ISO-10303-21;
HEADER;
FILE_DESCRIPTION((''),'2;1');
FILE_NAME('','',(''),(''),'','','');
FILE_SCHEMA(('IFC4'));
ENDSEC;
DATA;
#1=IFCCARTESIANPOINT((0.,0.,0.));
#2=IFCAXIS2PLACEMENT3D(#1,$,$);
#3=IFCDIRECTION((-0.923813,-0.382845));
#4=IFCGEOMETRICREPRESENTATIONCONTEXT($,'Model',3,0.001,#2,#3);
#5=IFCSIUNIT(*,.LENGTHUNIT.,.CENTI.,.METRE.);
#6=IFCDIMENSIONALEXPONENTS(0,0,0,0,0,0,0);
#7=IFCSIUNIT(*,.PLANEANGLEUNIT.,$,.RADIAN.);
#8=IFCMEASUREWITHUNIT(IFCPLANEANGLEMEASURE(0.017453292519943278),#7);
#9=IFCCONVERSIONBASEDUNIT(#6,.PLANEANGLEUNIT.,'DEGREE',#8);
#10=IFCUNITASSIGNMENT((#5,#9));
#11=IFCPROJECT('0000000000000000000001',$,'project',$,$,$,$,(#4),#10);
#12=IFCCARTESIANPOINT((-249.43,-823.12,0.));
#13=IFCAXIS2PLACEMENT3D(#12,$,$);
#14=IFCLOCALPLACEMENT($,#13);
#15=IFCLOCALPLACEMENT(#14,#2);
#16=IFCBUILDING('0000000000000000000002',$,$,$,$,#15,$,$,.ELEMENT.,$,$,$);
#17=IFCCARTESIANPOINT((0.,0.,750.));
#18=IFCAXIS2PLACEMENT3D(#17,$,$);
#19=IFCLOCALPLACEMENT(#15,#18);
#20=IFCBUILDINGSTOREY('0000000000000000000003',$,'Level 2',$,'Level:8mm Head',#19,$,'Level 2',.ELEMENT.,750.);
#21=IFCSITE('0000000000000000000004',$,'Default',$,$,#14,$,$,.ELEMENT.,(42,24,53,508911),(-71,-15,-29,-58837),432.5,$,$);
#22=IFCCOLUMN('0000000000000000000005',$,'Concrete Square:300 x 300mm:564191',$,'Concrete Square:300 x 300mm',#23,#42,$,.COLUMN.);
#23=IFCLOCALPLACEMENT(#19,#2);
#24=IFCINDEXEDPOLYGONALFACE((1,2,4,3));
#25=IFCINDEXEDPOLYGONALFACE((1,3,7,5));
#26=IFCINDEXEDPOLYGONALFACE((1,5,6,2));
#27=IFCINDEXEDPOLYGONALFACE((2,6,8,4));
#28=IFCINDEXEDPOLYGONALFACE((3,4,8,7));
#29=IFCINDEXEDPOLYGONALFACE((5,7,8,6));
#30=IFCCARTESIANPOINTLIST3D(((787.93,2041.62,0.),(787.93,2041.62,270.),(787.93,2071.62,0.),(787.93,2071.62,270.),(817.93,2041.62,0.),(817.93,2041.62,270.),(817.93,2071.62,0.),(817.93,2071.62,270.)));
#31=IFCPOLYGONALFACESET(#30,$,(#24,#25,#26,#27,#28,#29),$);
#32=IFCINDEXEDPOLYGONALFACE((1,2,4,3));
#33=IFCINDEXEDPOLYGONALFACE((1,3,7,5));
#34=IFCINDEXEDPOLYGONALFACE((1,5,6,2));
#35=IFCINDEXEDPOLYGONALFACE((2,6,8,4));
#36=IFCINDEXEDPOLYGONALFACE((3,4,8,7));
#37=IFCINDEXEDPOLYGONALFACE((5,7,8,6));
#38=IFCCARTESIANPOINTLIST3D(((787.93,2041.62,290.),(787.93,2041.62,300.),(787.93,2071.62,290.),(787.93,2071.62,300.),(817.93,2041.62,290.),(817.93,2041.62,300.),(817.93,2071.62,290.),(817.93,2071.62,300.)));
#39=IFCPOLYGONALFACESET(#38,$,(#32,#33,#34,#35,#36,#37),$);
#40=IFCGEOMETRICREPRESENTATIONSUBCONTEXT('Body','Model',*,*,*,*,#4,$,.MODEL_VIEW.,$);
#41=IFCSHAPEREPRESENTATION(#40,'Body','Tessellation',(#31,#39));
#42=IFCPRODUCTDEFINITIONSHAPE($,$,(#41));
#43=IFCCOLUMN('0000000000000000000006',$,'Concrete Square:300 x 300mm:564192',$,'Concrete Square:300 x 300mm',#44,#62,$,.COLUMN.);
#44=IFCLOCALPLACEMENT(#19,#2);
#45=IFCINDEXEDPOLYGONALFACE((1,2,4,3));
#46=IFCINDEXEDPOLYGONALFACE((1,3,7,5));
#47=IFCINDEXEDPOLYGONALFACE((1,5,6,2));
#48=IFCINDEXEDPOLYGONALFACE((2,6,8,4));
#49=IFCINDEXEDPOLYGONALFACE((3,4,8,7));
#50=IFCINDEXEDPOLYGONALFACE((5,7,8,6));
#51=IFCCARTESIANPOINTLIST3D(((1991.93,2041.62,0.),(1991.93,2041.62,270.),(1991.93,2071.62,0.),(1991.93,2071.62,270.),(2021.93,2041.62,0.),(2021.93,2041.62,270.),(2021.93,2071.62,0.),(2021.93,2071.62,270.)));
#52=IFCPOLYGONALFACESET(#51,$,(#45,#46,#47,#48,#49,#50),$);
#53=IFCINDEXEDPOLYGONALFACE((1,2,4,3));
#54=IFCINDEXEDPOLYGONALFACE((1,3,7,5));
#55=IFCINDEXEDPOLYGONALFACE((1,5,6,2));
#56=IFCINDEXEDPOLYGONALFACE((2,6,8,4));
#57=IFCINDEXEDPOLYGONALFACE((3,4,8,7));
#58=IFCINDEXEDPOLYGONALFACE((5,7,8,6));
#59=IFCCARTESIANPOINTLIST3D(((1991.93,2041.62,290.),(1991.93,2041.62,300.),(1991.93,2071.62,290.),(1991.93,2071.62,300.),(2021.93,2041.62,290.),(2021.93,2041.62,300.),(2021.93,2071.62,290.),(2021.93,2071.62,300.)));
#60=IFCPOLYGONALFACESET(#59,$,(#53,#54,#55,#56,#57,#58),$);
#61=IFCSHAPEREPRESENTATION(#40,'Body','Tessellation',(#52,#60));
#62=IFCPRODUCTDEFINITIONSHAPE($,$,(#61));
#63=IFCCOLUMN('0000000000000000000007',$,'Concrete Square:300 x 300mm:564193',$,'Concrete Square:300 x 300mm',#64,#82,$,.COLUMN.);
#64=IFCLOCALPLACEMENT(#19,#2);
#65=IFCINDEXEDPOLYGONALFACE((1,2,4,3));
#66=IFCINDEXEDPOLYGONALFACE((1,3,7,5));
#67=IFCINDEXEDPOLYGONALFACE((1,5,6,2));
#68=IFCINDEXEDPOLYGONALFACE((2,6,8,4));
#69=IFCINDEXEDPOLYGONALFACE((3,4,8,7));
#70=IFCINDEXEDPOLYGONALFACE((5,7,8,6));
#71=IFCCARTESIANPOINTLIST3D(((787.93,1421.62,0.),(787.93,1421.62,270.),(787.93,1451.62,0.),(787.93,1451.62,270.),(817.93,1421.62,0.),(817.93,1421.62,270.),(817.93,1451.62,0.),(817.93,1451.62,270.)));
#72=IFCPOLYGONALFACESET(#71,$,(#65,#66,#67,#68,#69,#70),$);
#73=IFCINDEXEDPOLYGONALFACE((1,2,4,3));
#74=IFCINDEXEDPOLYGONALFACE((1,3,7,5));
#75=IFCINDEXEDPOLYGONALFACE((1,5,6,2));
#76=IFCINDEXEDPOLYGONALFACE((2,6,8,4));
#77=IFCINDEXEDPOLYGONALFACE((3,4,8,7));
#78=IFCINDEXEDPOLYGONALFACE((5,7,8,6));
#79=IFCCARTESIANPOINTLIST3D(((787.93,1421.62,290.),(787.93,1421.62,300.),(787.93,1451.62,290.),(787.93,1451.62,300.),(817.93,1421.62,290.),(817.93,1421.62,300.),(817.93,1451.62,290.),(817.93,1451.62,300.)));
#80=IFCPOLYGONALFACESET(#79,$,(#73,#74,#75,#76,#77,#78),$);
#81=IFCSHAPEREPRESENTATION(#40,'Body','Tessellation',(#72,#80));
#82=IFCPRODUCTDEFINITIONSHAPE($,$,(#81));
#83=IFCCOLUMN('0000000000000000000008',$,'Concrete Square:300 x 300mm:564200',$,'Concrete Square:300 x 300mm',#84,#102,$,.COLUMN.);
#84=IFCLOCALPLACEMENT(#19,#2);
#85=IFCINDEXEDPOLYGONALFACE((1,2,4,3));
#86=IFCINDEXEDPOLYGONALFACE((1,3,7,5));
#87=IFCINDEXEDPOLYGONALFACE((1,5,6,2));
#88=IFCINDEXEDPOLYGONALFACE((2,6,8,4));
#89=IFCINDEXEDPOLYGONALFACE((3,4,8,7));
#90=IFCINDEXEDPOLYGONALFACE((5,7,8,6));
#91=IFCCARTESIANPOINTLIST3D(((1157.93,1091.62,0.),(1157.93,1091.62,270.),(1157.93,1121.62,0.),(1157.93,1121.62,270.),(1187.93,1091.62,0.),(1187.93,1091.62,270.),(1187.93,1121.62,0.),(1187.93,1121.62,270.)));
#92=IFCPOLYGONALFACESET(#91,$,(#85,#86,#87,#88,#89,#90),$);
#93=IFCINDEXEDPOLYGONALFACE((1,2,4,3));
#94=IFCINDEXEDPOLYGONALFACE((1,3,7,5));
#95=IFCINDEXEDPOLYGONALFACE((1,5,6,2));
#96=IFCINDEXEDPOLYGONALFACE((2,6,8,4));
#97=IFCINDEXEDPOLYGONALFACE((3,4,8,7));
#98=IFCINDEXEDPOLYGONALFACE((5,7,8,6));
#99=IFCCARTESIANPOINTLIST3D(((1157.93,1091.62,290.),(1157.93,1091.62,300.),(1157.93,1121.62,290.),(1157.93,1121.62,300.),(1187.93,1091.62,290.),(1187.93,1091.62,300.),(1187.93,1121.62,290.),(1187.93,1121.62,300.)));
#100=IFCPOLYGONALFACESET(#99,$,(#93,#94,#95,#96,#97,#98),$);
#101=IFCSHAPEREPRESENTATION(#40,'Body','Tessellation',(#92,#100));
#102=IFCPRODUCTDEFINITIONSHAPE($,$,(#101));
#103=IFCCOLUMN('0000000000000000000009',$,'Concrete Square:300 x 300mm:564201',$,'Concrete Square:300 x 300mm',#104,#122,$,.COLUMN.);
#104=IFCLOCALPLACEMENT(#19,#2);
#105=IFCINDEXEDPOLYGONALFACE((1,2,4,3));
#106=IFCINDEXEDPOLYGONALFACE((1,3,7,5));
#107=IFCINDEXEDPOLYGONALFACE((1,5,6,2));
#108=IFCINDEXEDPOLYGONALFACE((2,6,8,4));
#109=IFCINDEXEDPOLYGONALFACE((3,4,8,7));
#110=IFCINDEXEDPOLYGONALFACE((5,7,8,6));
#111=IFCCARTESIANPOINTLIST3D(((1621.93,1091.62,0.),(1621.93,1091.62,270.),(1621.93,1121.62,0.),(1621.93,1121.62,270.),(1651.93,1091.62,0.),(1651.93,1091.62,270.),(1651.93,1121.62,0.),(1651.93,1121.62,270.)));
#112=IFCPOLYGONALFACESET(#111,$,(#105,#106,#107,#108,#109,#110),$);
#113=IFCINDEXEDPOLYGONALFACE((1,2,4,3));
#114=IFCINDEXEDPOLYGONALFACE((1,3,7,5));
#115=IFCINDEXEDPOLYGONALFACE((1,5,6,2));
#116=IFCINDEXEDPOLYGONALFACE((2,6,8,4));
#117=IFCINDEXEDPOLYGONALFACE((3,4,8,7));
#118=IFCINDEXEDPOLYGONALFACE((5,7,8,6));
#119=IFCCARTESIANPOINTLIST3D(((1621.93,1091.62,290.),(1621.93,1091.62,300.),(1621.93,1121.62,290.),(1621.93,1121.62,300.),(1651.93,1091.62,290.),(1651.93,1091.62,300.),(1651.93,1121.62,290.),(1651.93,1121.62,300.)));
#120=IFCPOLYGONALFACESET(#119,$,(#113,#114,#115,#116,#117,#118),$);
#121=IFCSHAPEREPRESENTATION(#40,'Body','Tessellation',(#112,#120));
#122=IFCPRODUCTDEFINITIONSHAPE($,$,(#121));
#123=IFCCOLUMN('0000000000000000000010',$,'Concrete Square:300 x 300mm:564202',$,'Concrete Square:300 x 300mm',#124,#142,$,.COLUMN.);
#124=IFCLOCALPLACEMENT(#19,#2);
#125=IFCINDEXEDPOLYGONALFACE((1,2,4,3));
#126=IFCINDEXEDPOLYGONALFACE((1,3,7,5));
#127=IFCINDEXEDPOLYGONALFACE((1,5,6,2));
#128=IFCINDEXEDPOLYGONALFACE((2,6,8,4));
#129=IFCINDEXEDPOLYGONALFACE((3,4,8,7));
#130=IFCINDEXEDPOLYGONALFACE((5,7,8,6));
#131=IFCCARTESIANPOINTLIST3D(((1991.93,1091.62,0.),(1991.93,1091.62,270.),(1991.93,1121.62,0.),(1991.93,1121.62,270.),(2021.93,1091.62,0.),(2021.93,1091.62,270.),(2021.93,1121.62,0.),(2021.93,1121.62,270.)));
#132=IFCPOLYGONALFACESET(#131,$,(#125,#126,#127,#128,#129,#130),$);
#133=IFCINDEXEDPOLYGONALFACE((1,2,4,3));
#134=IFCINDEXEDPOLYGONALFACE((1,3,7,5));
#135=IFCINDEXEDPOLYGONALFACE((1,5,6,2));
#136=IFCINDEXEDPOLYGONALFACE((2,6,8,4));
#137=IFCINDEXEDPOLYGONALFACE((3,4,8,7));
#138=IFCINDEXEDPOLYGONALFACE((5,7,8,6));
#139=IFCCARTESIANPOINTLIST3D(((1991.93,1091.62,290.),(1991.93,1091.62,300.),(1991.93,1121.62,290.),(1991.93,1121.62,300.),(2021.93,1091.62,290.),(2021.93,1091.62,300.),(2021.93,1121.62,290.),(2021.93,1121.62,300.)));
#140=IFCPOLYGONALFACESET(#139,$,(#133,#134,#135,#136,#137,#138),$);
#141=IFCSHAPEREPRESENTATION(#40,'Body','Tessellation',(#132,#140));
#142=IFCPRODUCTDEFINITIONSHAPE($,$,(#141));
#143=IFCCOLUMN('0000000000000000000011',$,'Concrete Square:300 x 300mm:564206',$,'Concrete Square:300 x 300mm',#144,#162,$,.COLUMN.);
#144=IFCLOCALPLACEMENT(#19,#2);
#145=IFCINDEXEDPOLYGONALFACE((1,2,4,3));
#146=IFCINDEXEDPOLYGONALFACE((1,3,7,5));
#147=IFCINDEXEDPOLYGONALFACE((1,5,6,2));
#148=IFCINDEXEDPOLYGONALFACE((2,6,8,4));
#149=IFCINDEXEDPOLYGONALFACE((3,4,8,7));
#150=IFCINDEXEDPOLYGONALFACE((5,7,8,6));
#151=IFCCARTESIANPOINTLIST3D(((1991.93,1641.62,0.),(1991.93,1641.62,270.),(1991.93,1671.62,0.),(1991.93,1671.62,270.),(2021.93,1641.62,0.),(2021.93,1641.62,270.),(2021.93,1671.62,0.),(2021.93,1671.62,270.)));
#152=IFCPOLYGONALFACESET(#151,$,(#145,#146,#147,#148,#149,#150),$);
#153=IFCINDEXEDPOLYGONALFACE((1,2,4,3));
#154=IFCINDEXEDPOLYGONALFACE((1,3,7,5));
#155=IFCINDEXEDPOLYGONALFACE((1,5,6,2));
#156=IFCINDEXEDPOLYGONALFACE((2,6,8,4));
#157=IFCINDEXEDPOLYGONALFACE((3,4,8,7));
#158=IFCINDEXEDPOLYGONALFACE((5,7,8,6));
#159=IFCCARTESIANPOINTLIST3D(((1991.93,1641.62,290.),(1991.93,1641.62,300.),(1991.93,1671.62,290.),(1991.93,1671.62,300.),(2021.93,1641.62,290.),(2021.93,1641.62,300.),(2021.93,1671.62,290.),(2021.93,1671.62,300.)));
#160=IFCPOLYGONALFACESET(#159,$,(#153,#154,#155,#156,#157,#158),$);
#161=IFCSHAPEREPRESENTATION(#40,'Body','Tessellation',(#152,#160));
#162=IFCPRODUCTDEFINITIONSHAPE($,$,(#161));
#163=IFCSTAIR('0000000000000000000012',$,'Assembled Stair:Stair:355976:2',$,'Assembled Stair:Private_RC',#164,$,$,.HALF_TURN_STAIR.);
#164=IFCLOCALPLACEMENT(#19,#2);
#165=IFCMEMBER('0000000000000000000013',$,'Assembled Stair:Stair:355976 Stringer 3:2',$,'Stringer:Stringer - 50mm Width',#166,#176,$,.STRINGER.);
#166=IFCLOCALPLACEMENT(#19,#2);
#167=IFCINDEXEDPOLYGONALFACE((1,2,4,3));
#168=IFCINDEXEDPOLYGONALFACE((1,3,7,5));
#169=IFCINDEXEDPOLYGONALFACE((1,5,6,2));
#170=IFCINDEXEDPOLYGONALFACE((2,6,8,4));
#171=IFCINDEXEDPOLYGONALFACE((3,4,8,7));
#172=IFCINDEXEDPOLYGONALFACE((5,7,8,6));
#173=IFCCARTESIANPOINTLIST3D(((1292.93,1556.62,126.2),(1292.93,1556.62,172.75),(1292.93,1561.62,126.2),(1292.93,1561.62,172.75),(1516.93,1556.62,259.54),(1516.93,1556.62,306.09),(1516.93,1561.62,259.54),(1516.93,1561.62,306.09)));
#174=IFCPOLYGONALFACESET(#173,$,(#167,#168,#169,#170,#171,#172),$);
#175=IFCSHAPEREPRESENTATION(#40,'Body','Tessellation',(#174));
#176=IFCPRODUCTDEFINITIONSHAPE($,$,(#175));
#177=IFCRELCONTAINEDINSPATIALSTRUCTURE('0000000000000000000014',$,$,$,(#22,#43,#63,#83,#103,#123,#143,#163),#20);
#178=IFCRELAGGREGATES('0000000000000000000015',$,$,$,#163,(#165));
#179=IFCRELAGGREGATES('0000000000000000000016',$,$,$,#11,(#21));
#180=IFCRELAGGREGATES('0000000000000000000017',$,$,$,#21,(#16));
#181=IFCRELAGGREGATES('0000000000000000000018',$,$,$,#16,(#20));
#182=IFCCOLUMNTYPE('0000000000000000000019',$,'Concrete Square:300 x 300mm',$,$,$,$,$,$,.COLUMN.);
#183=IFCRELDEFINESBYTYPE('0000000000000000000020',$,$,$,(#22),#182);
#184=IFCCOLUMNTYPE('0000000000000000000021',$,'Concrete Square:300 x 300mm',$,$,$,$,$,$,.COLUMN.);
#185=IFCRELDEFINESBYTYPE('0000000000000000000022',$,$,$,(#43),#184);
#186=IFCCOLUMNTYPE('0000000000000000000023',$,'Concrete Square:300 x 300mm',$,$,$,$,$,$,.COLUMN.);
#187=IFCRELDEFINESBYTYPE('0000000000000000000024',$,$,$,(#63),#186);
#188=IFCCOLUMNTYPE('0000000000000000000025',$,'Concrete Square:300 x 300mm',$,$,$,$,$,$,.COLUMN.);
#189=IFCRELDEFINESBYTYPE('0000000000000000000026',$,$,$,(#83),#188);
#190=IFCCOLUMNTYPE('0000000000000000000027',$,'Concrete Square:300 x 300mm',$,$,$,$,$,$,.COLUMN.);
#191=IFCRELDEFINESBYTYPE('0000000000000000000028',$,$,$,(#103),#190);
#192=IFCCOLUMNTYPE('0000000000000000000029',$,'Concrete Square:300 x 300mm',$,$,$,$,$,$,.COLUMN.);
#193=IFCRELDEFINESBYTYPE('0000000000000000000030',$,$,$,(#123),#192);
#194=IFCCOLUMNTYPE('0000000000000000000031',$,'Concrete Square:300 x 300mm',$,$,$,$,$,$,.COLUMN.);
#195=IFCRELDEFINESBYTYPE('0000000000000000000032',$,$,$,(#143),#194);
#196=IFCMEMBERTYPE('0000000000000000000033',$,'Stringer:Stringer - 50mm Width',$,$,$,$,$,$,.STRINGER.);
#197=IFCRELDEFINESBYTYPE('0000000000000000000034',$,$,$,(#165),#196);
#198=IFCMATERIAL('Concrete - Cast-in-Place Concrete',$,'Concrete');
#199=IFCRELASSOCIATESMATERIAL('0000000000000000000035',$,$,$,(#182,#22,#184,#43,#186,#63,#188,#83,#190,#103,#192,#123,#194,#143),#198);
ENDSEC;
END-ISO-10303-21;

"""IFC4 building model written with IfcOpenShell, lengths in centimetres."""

from ifc_helpers import new_model, entity, si_unit, converted_unit, direction, frame, origin, place, context, subcontext, project, spatial, indexed_curve, outline, extrude, source, transform, mapped, material, type_object, type_shapes, element, aggregate, save


model = new_model("IFC4")

# Units and contexts
model_context = context("Model", 3, precision=0.001, world=origin(), true_north=direction((-0.923813, -0.382845)))
body_context = subcontext(model_context, "Body", "Model", "MODEL_VIEW")
ifc_project = project(units=[si_unit("LENGTHUNIT", "METRE", prefix="CENTI"), converted_unit("PLANEANGLEUNIT", "DEGREE", entity("IfcPlaneAngleMeasure", 0.017453292519943278), si_unit("PLANEANGLEUNIT", "RADIAN"), dimensions=[0, 0, 0, 0, 0, 0, 0])], contexts=[model_context])

# Site, building, storey
site_placement = place(None, frame((-249.43, -823.12, 0.0)))
site = spatial("IfcSite", under=ifc_project, at=site_placement, Name="Default", CompositionType="ELEMENT", RefLatitude=(42, 24, 53, 508911), RefLongitude=(-71, -15, -29, -58837), RefElevation=432.5)
building_placement = place(site_placement, origin())
building = spatial("IfcBuilding", under=site, at=building_placement, CompositionType="ELEMENT")
storey_placement = place(building_placement, frame((0.0, 0.0, 750.0)))
storey = spatial("IfcBuildingStorey", under=building, at=storey_placement, Name="Level 2", ObjectType="Level:8mm Head", LongName="Level 2", CompositionType="ELEMENT", Elevation=750.0)

# Columns
ifc_material_1 = material(Name="Concrete - Cast-in-Place Concrete", Category="Concrete")
column_type_1 = type_object("IfcColumnType", Name="Concrete Square:300 x 300mm", PredefinedType="COLUMN", material=ifc_material_1)
shared_shape_1 = source(origin(), body_context, "Body", "SweptSolid", [
    extrude(outline(indexed_curve([(-15.0, -15.0), (15.0, -15.0), (15.0, 15.0), (-15.0, 15.0), (-15.0, -15.0)], self_intersect=False)), frame((802.93, 2056.62, 750.0), z_axis=(0.0, 0.0, 1.0), x_axis=(-1.0, 0.0, 0.0)), (0.0, 0.0, 1.0), 270.0),
    extrude(outline(indexed_curve([(-15.0, -15.0), (15.0, -15.0), (15.0, 15.0), (-15.0, 15.0), (-15.0, -15.0)], self_intersect=False)), frame((802.93, 2056.62, 1040.0), z_axis=(0.0, 0.0, 1.0), x_axis=(-1.0, 0.0, 0.0)), (0.0, 0.0, 1.0), 10.0),
])
type_shapes(column_type_1, [shared_shape_1])
column_1_placement = place(storey_placement, frame((0.0, 0.0, -750.0)))
element("IfcColumn", 1, at=column_1_placement, inside=storey, type_object=column_type_1, material=ifc_material_1, Name="Concrete Square:300 x 300mm:564191", ObjectType="Concrete Square:300 x 300mm", PredefinedType="COLUMN", context=body_context, shape_type="MappedRepresentation", body=[
    mapped(shared_shape_1, transform((0.0, 0.0, 0.0), scale=1.0)),
])
column_type_2 = type_object("IfcColumnType", Name="Concrete Square:300 x 300mm", PredefinedType="COLUMN", material=ifc_material_1)
shared_shape_2 = source(origin(), body_context, "Body", "SweptSolid", [
    extrude(outline(indexed_curve([(-15.0, -15.0), (15.0, -15.0), (15.0, 15.0), (-15.0, 15.0), (-15.0, -15.0)], self_intersect=False)), frame((2006.93, 2056.62, 750.0), z_axis=(0.0, 0.0, 1.0), x_axis=(-1.0, 0.0, 0.0)), (0.0, 0.0, 1.0), 270.0),
    extrude(outline(indexed_curve([(-15.0, -15.0), (15.0, -15.0), (15.0, 15.0), (-15.0, 15.0), (-15.0, -15.0)], self_intersect=False)), frame((2006.93, 2056.62, 1040.0), z_axis=(0.0, 0.0, 1.0), x_axis=(-1.0, 0.0, 0.0)), (0.0, 0.0, 1.0), 10.0),
])
type_shapes(column_type_2, [shared_shape_2])
column_2_placement = place(storey_placement, frame((0.0, 0.0, -750.0)))
element("IfcColumn", 2, at=column_2_placement, inside=storey, type_object=column_type_2, material=ifc_material_1, Name="Concrete Square:300 x 300mm:564192", ObjectType="Concrete Square:300 x 300mm", PredefinedType="COLUMN", context=body_context, shape_type="MappedRepresentation", body=[
    mapped(shared_shape_2, transform((0.0, 0.0, 0.0), scale=1.0)),
])
column_type_3 = type_object("IfcColumnType", Name="Concrete Square:300 x 300mm", PredefinedType="COLUMN", material=ifc_material_1)
shared_shape_3 = source(origin(), body_context, "Body", "SweptSolid", [
    extrude(outline(indexed_curve([(-15.0, -15.0), (15.0, -15.0), (15.0, 15.0), (-15.0, 15.0), (-15.0, -15.0)], self_intersect=False)), frame((802.93, 1436.62, 750.0), z_axis=(0.0, 0.0, 1.0), x_axis=(-1.0, 0.0, 0.0)), (0.0, 0.0, 1.0), 270.0),
    extrude(outline(indexed_curve([(-15.0, -15.0), (15.0, -15.0), (15.0, 15.0), (-15.0, 15.0), (-15.0, -15.0)], self_intersect=False)), frame((802.93, 1436.62, 1040.0), z_axis=(0.0, 0.0, 1.0), x_axis=(-1.0, 0.0, 0.0)), (0.0, 0.0, 1.0), 10.0),
])
type_shapes(column_type_3, [shared_shape_3])
column_3_placement = place(storey_placement, frame((0.0, 0.0, -750.0)))
element("IfcColumn", 3, at=column_3_placement, inside=storey, type_object=column_type_3, material=ifc_material_1, Name="Concrete Square:300 x 300mm:564193", ObjectType="Concrete Square:300 x 300mm", PredefinedType="COLUMN", context=body_context, shape_type="MappedRepresentation", body=[
    mapped(shared_shape_3, transform((0.0, 0.0, 0.0), scale=1.0)),
])
column_type_4 = type_object("IfcColumnType", Name="Concrete Square:300 x 300mm", PredefinedType="COLUMN", material=ifc_material_1)
shared_shape_4 = source(origin(), body_context, "Body", "SweptSolid", [
    extrude(outline(indexed_curve([(-15.0, -15.0), (15.0, -15.0), (15.0, 15.0), (-15.0, 15.0), (-15.0, -15.0)], self_intersect=False)), frame((1172.93, 1106.62, 750.0), z_axis=(0.0, 0.0, 1.0), x_axis=(-1.0, 0.0, 0.0)), (0.0, 0.0, 1.0), 270.0),
    extrude(outline(indexed_curve([(-15.0, -15.0), (15.0, -15.0), (15.0, 15.0), (-15.0, 15.0), (-15.0, -15.0)], self_intersect=False)), frame((1172.93, 1106.62, 1040.0), z_axis=(0.0, 0.0, 1.0), x_axis=(-1.0, 0.0, 0.0)), (0.0, 0.0, 1.0), 10.0),
])
type_shapes(column_type_4, [shared_shape_4])
column_4_placement = place(storey_placement, frame((0.0, 0.0, -750.0)))
element("IfcColumn", 4, at=column_4_placement, inside=storey, type_object=column_type_4, material=ifc_material_1, Name="Concrete Square:300 x 300mm:564200", ObjectType="Concrete Square:300 x 300mm", PredefinedType="COLUMN", context=body_context, shape_type="MappedRepresentation", body=[
    mapped(shared_shape_4, transform((0.0, 0.0, 0.0), scale=1.0)),
])
column_type_5 = type_object("IfcColumnType", Name="Concrete Square:300 x 300mm", PredefinedType="COLUMN", material=ifc_material_1)
shared_shape_5 = source(origin(), body_context, "Body", "SweptSolid", [
    extrude(outline(indexed_curve([(-15.0, -15.0), (15.0, -15.0), (15.0, 15.0), (-15.0, 15.0), (-15.0, -15.0)], self_intersect=False)), frame((1636.93, 1106.62, 750.0), z_axis=(0.0, 0.0, 1.0), x_axis=(-1.0, 0.0, 0.0)), (0.0, 0.0, 1.0), 270.0),
    extrude(outline(indexed_curve([(-15.0, -15.0), (15.0, -15.0), (15.0, 15.0), (-15.0, 15.0), (-15.0, -15.0)], self_intersect=False)), frame((1636.93, 1106.62, 1040.0), z_axis=(0.0, 0.0, 1.0), x_axis=(-1.0, 0.0, 0.0)), (0.0, 0.0, 1.0), 10.0),
])
type_shapes(column_type_5, [shared_shape_5])
column_5_placement = place(storey_placement, frame((0.0, 0.0, -750.0)))
element("IfcColumn", 5, at=column_5_placement, inside=storey, type_object=column_type_5, material=ifc_material_1, Name="Concrete Square:300 x 300mm:564201", ObjectType="Concrete Square:300 x 300mm", PredefinedType="COLUMN", context=body_context, shape_type="MappedRepresentation", body=[
    mapped(shared_shape_5, transform((0.0, 0.0, 0.0), scale=1.0)),
])
column_type_6 = type_object("IfcColumnType", Name="Concrete Square:300 x 300mm", PredefinedType="COLUMN", material=ifc_material_1)
shared_shape_6 = source(origin(), body_context, "Body", "SweptSolid", [
    extrude(outline(indexed_curve([(-15.0, -15.0), (15.0, -15.0), (15.0, 15.0), (-15.0, 15.0), (-15.0, -15.0)], self_intersect=False)), frame((2006.93, 1106.62, 750.0), z_axis=(0.0, 0.0, 1.0), x_axis=(-1.0, 0.0, 0.0)), (0.0, 0.0, 1.0), 270.0),
    extrude(outline(indexed_curve([(-15.0, -15.0), (15.0, -15.0), (15.0, 15.0), (-15.0, 15.0), (-15.0, -15.0)], self_intersect=False)), frame((2006.93, 1106.62, 1040.0), z_axis=(0.0, 0.0, 1.0), x_axis=(-1.0, 0.0, 0.0)), (0.0, 0.0, 1.0), 10.0),
])
type_shapes(column_type_6, [shared_shape_6])
column_6_placement = place(storey_placement, frame((0.0, 0.0, -750.0)))
element("IfcColumn", 6, at=column_6_placement, inside=storey, type_object=column_type_6, material=ifc_material_1, Name="Concrete Square:300 x 300mm:564202", ObjectType="Concrete Square:300 x 300mm", PredefinedType="COLUMN", context=body_context, shape_type="MappedRepresentation", body=[
    mapped(shared_shape_6, transform((0.0, 0.0, 0.0), scale=1.0)),
])
column_type_7 = type_object("IfcColumnType", Name="Concrete Square:300 x 300mm", PredefinedType="COLUMN", material=ifc_material_1)
shared_shape_7 = source(origin(), body_context, "Body", "SweptSolid", [
    extrude(outline(indexed_curve([(-15.0, -15.0), (15.0, -15.0), (15.0, 15.0), (-15.0, 15.0), (-15.0, -15.0)], self_intersect=False)), frame((2006.93, 1656.62, 750.0), z_axis=(0.0, 0.0, 1.0), x_axis=(-1.0, 0.0, 0.0)), (0.0, 0.0, 1.0), 270.0),
    extrude(outline(indexed_curve([(-15.0, -15.0), (15.0, -15.0), (15.0, 15.0), (-15.0, 15.0), (-15.0, -15.0)], self_intersect=False)), frame((2006.93, 1656.62, 1040.0), z_axis=(0.0, 0.0, 1.0), x_axis=(-1.0, 0.0, 0.0)), (0.0, 0.0, 1.0), 10.0),
])
type_shapes(column_type_7, [shared_shape_7])
column_7_placement = place(storey_placement, frame((0.0, 0.0, -750.0)))
element("IfcColumn", 7, at=column_7_placement, inside=storey, type_object=column_type_7, material=ifc_material_1, Name="Concrete Square:300 x 300mm:564206", ObjectType="Concrete Square:300 x 300mm", PredefinedType="COLUMN", context=body_context, shape_type="MappedRepresentation", body=[
    mapped(shared_shape_7, transform((0.0, 0.0, 0.0), scale=1.0)),
])

# Stair, member
stair_placement = place(storey_placement, origin())
stair = element("IfcStair", 8, at=stair_placement, inside=storey, Name="Assembled Stair:Stair:355976:2", ObjectType="Assembled Stair:Private_RC", PredefinedType="HALF_TURN_STAIR")
member_type = type_object("IfcMemberType", Name="Stringer:Stringer - 50mm Width", PredefinedType="STRINGER")
member_1_placement = place(stair_placement, origin())
member_1 = element("IfcMember", 9, at=member_1_placement, type_object=member_type, Name="Assembled Stair:Stair:355976 Stringer 3:2", ObjectType="Stringer:Stringer - 50mm Width", PredefinedType="STRINGER", context=body_context, shape_type="SweptSolid", body=[
    extrude(outline(indexed_curve([(-118.43, -20.0), (142.24, -20.0), (118.43, 20.0), (-142.24, 20.0), (-118.43, -20.0)], self_intersect=False)), frame((1404.93, 1556.62, 216.15), z_axis=(0.0, 1.0, 0.0), x_axis=(0.859293, 0.0, 0.511484)), (0.0, 0.0, 1.0), 5.0),
])

aggregate(stair, [member_1])

save(model, "model.ifc")
